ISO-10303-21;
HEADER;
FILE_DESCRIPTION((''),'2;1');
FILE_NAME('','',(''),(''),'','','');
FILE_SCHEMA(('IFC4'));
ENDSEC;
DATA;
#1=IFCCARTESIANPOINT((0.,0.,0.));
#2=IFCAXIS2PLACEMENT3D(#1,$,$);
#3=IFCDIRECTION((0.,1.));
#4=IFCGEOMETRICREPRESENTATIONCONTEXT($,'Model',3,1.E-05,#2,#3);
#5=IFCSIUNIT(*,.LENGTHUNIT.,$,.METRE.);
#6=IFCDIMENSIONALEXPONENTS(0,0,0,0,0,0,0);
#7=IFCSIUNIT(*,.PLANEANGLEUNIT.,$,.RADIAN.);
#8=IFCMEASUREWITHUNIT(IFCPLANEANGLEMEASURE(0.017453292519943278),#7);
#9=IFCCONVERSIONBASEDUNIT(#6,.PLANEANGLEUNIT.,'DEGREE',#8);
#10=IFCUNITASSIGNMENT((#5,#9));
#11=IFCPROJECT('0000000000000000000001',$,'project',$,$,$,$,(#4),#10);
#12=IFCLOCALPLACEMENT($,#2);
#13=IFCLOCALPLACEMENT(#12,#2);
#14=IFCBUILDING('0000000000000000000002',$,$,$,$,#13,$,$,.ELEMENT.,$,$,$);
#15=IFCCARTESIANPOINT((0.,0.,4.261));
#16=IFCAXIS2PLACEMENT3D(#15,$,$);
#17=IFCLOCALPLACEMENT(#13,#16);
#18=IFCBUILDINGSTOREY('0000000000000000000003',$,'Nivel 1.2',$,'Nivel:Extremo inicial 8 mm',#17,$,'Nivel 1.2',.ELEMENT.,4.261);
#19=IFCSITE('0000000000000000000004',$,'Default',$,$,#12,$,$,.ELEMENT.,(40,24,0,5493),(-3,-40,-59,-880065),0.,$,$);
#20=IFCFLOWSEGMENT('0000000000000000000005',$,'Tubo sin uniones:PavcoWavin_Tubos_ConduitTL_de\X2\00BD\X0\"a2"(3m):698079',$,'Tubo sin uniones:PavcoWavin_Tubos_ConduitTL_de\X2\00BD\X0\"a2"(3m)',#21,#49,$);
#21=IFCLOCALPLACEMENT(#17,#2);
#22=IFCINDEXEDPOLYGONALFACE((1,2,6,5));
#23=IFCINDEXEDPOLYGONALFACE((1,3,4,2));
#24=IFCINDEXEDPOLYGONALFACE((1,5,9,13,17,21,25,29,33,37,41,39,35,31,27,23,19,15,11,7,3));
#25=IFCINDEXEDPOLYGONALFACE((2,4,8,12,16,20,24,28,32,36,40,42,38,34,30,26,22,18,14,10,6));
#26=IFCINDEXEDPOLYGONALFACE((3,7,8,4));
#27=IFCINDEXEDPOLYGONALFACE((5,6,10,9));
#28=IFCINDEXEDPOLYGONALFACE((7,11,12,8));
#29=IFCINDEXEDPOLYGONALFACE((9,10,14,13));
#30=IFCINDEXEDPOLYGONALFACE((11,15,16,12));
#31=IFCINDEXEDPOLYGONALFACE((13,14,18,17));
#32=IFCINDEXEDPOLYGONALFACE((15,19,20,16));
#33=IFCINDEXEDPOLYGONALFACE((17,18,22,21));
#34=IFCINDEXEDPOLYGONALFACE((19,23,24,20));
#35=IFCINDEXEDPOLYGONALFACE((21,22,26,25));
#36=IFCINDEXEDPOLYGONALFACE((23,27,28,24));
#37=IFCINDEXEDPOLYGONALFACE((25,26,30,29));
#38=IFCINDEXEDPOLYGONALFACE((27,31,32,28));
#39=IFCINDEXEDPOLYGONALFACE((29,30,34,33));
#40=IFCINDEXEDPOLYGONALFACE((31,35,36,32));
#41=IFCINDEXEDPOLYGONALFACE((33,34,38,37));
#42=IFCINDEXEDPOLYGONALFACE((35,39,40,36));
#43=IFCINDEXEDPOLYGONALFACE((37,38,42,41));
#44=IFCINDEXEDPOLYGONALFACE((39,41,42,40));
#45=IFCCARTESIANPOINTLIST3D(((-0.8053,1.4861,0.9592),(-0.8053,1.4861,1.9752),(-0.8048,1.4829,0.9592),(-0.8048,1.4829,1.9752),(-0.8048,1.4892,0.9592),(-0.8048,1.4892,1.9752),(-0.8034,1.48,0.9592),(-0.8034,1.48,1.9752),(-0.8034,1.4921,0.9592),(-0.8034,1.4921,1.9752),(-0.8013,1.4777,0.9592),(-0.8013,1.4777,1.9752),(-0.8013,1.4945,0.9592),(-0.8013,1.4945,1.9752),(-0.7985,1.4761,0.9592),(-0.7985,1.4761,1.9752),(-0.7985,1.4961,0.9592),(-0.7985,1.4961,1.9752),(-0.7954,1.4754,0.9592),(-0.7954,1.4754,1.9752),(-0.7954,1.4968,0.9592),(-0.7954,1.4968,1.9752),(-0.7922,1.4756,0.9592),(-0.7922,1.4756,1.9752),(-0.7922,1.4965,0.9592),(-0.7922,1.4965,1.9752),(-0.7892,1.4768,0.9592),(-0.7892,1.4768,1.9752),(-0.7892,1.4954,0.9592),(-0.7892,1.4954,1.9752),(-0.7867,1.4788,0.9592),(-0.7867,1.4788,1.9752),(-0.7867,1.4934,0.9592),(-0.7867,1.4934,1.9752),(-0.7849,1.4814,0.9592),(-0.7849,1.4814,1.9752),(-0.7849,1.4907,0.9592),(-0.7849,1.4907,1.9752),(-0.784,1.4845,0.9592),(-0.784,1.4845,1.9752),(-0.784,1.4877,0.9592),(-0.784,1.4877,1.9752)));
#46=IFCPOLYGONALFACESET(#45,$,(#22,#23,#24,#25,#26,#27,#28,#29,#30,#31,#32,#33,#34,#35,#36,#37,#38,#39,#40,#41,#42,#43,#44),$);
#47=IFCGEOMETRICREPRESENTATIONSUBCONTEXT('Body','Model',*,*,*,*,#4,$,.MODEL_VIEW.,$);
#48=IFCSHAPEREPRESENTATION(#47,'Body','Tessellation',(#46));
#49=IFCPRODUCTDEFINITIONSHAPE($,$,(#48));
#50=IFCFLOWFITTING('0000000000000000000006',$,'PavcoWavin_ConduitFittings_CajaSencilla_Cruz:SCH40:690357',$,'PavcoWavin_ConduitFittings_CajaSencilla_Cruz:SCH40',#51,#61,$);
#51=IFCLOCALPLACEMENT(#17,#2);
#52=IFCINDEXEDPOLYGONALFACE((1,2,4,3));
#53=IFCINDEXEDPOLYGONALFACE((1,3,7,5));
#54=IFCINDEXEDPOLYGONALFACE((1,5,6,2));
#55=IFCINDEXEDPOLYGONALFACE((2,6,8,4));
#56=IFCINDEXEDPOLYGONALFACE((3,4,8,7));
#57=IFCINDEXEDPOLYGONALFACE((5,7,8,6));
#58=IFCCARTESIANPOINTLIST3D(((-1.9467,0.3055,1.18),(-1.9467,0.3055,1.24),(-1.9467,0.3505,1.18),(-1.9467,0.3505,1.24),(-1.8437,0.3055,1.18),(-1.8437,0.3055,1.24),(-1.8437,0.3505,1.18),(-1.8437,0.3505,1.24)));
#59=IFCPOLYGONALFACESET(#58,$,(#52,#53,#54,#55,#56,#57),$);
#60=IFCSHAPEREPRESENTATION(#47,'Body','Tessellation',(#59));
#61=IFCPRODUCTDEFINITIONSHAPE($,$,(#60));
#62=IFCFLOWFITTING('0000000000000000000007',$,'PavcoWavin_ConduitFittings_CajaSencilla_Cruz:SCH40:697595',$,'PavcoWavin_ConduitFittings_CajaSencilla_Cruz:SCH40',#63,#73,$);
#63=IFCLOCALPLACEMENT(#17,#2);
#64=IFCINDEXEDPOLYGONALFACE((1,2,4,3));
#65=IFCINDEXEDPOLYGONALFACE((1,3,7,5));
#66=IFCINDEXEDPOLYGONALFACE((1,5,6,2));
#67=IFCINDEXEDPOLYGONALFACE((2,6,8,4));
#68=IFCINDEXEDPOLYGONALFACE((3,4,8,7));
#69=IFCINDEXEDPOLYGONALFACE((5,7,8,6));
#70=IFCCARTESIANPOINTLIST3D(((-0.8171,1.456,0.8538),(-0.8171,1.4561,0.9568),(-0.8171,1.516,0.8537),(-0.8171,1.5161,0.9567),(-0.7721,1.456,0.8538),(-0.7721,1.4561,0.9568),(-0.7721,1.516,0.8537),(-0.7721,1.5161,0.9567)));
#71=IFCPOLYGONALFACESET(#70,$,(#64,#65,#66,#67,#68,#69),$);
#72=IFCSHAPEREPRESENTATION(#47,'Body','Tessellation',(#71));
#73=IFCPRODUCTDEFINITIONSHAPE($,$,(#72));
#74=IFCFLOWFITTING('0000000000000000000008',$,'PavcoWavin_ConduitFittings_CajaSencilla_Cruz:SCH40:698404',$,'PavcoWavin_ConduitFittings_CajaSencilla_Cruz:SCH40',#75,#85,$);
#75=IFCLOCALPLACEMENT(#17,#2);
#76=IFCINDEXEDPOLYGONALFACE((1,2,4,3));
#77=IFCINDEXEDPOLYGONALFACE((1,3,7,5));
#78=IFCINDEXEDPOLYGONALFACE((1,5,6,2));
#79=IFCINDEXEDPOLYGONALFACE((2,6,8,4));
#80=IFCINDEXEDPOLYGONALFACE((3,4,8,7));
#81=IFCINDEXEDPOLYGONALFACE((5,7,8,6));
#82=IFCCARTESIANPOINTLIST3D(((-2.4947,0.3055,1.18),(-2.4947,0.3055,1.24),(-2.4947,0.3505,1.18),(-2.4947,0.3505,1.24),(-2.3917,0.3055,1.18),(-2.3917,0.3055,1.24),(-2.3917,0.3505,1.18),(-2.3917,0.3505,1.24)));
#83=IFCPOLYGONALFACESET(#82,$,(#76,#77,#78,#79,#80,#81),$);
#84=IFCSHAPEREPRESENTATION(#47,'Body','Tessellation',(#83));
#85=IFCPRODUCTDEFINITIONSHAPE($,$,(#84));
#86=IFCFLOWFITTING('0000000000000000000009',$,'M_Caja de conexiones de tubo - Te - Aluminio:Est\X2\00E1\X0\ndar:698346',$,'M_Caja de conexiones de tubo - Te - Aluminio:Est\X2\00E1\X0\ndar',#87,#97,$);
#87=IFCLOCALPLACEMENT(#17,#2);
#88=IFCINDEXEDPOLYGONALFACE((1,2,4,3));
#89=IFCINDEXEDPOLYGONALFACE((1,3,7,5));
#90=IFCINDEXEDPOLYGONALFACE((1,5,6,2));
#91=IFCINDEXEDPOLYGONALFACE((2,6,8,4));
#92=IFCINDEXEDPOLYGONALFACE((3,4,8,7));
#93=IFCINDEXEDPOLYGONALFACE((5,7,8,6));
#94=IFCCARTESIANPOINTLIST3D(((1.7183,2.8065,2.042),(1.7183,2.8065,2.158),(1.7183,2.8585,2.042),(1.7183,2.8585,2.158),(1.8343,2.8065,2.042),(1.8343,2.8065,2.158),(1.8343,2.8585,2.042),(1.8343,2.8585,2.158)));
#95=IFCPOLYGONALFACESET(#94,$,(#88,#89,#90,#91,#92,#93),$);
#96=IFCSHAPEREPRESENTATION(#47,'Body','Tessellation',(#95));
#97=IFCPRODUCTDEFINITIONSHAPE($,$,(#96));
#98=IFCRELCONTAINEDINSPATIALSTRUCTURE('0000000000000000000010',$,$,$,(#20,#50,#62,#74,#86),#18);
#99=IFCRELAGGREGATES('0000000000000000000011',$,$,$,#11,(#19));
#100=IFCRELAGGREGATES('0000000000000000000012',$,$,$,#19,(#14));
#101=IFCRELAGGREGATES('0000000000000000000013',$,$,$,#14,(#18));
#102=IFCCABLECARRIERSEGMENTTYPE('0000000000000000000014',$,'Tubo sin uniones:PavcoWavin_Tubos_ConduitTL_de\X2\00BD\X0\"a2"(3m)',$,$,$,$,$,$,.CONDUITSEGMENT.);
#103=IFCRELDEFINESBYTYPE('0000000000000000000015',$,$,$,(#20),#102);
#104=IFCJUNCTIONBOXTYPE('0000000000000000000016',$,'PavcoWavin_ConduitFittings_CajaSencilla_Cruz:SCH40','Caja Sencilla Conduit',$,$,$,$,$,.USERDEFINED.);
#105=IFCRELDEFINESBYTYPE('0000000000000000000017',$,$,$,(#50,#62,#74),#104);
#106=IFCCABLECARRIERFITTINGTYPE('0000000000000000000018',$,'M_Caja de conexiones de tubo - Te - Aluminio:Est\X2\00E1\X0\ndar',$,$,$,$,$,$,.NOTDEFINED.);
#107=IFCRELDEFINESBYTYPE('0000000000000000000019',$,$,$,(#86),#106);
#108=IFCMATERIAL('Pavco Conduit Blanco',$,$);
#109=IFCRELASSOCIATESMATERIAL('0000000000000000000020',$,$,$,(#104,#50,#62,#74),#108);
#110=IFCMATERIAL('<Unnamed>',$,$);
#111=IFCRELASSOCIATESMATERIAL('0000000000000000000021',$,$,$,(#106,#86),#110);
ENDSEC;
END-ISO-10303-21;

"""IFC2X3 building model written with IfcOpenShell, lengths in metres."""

from ifc_helpers import new_model, entity, si_unit, converted_unit, direction, frame, frame_2d, origin, origin_2d_with_axis, place, context, subcontext, project, spatial, rectangle, circle, extrude, source, transform, mapped, material, type_object, type_shapes, element, save


model = new_model("IFC2X3")

# Units and contexts
model_context = context("Model", 3, precision=1e-05, world=origin(), true_north=direction((0.0, 1.0)))
body_context = subcontext(model_context, "Body", "Model", "MODEL_VIEW")
ifc_project = project(units=[si_unit("LENGTHUNIT", "METRE"), converted_unit("PLANEANGLEUNIT", "DEGREE", entity("IfcPlaneAngleMeasure", 0.017453292519943278), si_unit("PLANEANGLEUNIT", "RADIAN"), dimensions=[0, 0, 0, 0, 0, 0, 0])], contexts=[model_context])

# Site, building, storey
site_placement = place(None, origin())
site = spatial("IfcSite", under=ifc_project, at=site_placement, Name="Default", CompositionType="ELEMENT", RefLatitude=(40, 24, 0, 5493), RefLongitude=(-3, -40, -59, -880065), RefElevation=0.0)
building_placement = place(site_placement, origin())
building = spatial("IfcBuilding", under=site, at=building_placement, CompositionType="ELEMENT")
storey_placement = place(building_placement, frame((0.0, 0.0, 4.261)))
storey = spatial("IfcBuildingStorey", under=building, at=storey_placement, Name="Nivel 1.2", ObjectType="Nivel:Extremo inicial 8 mm", LongName="Nivel 1.2", CompositionType="ELEMENT", Elevation=4.261)

# Shared definitions
ifc_material_1 = material(Name="<Unnamed>")

# Flow segment
cable_carrier_segment_type_1 = type_object("IfcCableCarrierSegmentType", Name="Tubo sin uniones:PavcoWavin_Tubos_ConduitTL_de½\"a2\"(3m)", PredefinedType="CONDUITSEGMENT")
flow_segment_1_placement = place(storey_placement, origin())
element("IfcFlowSegment", 1, at=flow_segment_1_placement, inside=storey, type_object=cable_carrier_segment_type_1, Name="Tubo sin uniones:PavcoWavin_Tubos_ConduitTL_de½\"a2\"(3m):698079", ObjectType="Tubo sin uniones:PavcoWavin_Tubos_ConduitTL_de½\"a2\"(3m)", context=body_context, shape_type="SweptSolid", body=[
    extrude(circle(Radius=0.0107, at=origin_2d_with_axis()), frame((-0.7946, 1.4861, 0.9592), z_axis=(0.0, 0.0, 1.0), x_axis=(-1.0, 0.0, 0.0)), (0.0, 0.0, 1.0), 1.016),
])

# Flow fittings
ifc_material_2 = material(Name="Pavco Conduit Blanco")
junction_box_type = type_object("IfcJunctionBoxType", Name="PavcoWavin_ConduitFittings_CajaSencilla_Cruz:SCH40", Description="Caja Sencilla Conduit", PredefinedType="USERDEFINED", material=ifc_material_2)
shared_shape_1 = source(origin(), body_context, "Body", "SweptSolid", [
    extrude(rectangle(XDim=0.103, YDim=0.06, at=origin_2d_with_axis()), frame((-0.028, 0.0, -0.0225), z_axis=(0.0, 0.0, 1.0), x_axis=(-1.0, 0.0, 0.0)), (0.0, 0.0, 1.0), 0.045),
])
type_shapes(junction_box_type, [shared_shape_1])
for number, where, z_axis, x_axis, name in (
    (2, (-1.9232, 0.328, 1.21), (0.0, 1.0, 0.0), (-1.0, 0.0, 0.0), "PavcoWavin_ConduitFittings_CajaSencilla_Cruz:SCH40:690357"),
    (3, (-0.7946, 1.486, 0.8772), (-1.0, 0.0, 0.0), (0.0, -0.001005, -0.999999), "PavcoWavin_ConduitFittings_CajaSencilla_Cruz:SCH40:697595"),
    (4, (-2.4712, 0.328, 1.21), (0.0, 1.0, 0.0), (-1.0, 0.0, 0.0), "PavcoWavin_ConduitFittings_CajaSencilla_Cruz:SCH40:698404"),
):
    element("IfcFlowFitting", number, at=place(storey_placement, frame(where, z_axis=z_axis, x_axis=x_axis)), inside=storey, type_object=junction_box_type, material=ifc_material_2, Name=name, ObjectType="PavcoWavin_ConduitFittings_CajaSencilla_Cruz:SCH40", context=body_context, shape_type="MappedRepresentation", body=[
        mapped(shared_shape_1, transform((0.0, 0.0, 0.0), scale=1.0)),
    ])
cable_carrier_fitting_type_1 = type_object("IfcCableCarrierFittingType", Name="M_Caja de conexiones de tubo - Te - Aluminio:Estándar", PredefinedType="NOTDEFINED", material=ifc_material_1)
shared_shape_2 = source(origin(), body_context, "Body", "SweptSolid", [
    extrude(rectangle(XDim=0.116, YDim=0.116, at=frame_2d((0.0, 0.0), x_axis=(1.0, 0.0))), frame((0.0, 0.0, -0.026), z_axis=(0.0, 0.0, 1.0), x_axis=(-1.0, 0.0, 0.0)), (0.0, 0.0, 1.0), 0.052),
])
type_shapes(cable_carrier_fitting_type_1, [shared_shape_2])
flow_fitting_1_placement = place(storey_placement, frame((1.7763, 2.8325, 2.1), z_axis=(0.0, -1.0, 0.0), x_axis=(0.0, 0.0, -1.0)))
element("IfcFlowFitting", 5, at=flow_fitting_1_placement, inside=storey, type_object=cable_carrier_fitting_type_1, material=ifc_material_1, Name="M_Caja de conexiones de tubo - Te - Aluminio:Estándar:698346", ObjectType="M_Caja de conexiones de tubo - Te - Aluminio:Estándar", context=body_context, shape_type="MappedRepresentation", body=[
    mapped(shared_shape_2, transform((0.0, 0.0, 0.0), scale=1.0)),
])

save(model, "model.ifc")
